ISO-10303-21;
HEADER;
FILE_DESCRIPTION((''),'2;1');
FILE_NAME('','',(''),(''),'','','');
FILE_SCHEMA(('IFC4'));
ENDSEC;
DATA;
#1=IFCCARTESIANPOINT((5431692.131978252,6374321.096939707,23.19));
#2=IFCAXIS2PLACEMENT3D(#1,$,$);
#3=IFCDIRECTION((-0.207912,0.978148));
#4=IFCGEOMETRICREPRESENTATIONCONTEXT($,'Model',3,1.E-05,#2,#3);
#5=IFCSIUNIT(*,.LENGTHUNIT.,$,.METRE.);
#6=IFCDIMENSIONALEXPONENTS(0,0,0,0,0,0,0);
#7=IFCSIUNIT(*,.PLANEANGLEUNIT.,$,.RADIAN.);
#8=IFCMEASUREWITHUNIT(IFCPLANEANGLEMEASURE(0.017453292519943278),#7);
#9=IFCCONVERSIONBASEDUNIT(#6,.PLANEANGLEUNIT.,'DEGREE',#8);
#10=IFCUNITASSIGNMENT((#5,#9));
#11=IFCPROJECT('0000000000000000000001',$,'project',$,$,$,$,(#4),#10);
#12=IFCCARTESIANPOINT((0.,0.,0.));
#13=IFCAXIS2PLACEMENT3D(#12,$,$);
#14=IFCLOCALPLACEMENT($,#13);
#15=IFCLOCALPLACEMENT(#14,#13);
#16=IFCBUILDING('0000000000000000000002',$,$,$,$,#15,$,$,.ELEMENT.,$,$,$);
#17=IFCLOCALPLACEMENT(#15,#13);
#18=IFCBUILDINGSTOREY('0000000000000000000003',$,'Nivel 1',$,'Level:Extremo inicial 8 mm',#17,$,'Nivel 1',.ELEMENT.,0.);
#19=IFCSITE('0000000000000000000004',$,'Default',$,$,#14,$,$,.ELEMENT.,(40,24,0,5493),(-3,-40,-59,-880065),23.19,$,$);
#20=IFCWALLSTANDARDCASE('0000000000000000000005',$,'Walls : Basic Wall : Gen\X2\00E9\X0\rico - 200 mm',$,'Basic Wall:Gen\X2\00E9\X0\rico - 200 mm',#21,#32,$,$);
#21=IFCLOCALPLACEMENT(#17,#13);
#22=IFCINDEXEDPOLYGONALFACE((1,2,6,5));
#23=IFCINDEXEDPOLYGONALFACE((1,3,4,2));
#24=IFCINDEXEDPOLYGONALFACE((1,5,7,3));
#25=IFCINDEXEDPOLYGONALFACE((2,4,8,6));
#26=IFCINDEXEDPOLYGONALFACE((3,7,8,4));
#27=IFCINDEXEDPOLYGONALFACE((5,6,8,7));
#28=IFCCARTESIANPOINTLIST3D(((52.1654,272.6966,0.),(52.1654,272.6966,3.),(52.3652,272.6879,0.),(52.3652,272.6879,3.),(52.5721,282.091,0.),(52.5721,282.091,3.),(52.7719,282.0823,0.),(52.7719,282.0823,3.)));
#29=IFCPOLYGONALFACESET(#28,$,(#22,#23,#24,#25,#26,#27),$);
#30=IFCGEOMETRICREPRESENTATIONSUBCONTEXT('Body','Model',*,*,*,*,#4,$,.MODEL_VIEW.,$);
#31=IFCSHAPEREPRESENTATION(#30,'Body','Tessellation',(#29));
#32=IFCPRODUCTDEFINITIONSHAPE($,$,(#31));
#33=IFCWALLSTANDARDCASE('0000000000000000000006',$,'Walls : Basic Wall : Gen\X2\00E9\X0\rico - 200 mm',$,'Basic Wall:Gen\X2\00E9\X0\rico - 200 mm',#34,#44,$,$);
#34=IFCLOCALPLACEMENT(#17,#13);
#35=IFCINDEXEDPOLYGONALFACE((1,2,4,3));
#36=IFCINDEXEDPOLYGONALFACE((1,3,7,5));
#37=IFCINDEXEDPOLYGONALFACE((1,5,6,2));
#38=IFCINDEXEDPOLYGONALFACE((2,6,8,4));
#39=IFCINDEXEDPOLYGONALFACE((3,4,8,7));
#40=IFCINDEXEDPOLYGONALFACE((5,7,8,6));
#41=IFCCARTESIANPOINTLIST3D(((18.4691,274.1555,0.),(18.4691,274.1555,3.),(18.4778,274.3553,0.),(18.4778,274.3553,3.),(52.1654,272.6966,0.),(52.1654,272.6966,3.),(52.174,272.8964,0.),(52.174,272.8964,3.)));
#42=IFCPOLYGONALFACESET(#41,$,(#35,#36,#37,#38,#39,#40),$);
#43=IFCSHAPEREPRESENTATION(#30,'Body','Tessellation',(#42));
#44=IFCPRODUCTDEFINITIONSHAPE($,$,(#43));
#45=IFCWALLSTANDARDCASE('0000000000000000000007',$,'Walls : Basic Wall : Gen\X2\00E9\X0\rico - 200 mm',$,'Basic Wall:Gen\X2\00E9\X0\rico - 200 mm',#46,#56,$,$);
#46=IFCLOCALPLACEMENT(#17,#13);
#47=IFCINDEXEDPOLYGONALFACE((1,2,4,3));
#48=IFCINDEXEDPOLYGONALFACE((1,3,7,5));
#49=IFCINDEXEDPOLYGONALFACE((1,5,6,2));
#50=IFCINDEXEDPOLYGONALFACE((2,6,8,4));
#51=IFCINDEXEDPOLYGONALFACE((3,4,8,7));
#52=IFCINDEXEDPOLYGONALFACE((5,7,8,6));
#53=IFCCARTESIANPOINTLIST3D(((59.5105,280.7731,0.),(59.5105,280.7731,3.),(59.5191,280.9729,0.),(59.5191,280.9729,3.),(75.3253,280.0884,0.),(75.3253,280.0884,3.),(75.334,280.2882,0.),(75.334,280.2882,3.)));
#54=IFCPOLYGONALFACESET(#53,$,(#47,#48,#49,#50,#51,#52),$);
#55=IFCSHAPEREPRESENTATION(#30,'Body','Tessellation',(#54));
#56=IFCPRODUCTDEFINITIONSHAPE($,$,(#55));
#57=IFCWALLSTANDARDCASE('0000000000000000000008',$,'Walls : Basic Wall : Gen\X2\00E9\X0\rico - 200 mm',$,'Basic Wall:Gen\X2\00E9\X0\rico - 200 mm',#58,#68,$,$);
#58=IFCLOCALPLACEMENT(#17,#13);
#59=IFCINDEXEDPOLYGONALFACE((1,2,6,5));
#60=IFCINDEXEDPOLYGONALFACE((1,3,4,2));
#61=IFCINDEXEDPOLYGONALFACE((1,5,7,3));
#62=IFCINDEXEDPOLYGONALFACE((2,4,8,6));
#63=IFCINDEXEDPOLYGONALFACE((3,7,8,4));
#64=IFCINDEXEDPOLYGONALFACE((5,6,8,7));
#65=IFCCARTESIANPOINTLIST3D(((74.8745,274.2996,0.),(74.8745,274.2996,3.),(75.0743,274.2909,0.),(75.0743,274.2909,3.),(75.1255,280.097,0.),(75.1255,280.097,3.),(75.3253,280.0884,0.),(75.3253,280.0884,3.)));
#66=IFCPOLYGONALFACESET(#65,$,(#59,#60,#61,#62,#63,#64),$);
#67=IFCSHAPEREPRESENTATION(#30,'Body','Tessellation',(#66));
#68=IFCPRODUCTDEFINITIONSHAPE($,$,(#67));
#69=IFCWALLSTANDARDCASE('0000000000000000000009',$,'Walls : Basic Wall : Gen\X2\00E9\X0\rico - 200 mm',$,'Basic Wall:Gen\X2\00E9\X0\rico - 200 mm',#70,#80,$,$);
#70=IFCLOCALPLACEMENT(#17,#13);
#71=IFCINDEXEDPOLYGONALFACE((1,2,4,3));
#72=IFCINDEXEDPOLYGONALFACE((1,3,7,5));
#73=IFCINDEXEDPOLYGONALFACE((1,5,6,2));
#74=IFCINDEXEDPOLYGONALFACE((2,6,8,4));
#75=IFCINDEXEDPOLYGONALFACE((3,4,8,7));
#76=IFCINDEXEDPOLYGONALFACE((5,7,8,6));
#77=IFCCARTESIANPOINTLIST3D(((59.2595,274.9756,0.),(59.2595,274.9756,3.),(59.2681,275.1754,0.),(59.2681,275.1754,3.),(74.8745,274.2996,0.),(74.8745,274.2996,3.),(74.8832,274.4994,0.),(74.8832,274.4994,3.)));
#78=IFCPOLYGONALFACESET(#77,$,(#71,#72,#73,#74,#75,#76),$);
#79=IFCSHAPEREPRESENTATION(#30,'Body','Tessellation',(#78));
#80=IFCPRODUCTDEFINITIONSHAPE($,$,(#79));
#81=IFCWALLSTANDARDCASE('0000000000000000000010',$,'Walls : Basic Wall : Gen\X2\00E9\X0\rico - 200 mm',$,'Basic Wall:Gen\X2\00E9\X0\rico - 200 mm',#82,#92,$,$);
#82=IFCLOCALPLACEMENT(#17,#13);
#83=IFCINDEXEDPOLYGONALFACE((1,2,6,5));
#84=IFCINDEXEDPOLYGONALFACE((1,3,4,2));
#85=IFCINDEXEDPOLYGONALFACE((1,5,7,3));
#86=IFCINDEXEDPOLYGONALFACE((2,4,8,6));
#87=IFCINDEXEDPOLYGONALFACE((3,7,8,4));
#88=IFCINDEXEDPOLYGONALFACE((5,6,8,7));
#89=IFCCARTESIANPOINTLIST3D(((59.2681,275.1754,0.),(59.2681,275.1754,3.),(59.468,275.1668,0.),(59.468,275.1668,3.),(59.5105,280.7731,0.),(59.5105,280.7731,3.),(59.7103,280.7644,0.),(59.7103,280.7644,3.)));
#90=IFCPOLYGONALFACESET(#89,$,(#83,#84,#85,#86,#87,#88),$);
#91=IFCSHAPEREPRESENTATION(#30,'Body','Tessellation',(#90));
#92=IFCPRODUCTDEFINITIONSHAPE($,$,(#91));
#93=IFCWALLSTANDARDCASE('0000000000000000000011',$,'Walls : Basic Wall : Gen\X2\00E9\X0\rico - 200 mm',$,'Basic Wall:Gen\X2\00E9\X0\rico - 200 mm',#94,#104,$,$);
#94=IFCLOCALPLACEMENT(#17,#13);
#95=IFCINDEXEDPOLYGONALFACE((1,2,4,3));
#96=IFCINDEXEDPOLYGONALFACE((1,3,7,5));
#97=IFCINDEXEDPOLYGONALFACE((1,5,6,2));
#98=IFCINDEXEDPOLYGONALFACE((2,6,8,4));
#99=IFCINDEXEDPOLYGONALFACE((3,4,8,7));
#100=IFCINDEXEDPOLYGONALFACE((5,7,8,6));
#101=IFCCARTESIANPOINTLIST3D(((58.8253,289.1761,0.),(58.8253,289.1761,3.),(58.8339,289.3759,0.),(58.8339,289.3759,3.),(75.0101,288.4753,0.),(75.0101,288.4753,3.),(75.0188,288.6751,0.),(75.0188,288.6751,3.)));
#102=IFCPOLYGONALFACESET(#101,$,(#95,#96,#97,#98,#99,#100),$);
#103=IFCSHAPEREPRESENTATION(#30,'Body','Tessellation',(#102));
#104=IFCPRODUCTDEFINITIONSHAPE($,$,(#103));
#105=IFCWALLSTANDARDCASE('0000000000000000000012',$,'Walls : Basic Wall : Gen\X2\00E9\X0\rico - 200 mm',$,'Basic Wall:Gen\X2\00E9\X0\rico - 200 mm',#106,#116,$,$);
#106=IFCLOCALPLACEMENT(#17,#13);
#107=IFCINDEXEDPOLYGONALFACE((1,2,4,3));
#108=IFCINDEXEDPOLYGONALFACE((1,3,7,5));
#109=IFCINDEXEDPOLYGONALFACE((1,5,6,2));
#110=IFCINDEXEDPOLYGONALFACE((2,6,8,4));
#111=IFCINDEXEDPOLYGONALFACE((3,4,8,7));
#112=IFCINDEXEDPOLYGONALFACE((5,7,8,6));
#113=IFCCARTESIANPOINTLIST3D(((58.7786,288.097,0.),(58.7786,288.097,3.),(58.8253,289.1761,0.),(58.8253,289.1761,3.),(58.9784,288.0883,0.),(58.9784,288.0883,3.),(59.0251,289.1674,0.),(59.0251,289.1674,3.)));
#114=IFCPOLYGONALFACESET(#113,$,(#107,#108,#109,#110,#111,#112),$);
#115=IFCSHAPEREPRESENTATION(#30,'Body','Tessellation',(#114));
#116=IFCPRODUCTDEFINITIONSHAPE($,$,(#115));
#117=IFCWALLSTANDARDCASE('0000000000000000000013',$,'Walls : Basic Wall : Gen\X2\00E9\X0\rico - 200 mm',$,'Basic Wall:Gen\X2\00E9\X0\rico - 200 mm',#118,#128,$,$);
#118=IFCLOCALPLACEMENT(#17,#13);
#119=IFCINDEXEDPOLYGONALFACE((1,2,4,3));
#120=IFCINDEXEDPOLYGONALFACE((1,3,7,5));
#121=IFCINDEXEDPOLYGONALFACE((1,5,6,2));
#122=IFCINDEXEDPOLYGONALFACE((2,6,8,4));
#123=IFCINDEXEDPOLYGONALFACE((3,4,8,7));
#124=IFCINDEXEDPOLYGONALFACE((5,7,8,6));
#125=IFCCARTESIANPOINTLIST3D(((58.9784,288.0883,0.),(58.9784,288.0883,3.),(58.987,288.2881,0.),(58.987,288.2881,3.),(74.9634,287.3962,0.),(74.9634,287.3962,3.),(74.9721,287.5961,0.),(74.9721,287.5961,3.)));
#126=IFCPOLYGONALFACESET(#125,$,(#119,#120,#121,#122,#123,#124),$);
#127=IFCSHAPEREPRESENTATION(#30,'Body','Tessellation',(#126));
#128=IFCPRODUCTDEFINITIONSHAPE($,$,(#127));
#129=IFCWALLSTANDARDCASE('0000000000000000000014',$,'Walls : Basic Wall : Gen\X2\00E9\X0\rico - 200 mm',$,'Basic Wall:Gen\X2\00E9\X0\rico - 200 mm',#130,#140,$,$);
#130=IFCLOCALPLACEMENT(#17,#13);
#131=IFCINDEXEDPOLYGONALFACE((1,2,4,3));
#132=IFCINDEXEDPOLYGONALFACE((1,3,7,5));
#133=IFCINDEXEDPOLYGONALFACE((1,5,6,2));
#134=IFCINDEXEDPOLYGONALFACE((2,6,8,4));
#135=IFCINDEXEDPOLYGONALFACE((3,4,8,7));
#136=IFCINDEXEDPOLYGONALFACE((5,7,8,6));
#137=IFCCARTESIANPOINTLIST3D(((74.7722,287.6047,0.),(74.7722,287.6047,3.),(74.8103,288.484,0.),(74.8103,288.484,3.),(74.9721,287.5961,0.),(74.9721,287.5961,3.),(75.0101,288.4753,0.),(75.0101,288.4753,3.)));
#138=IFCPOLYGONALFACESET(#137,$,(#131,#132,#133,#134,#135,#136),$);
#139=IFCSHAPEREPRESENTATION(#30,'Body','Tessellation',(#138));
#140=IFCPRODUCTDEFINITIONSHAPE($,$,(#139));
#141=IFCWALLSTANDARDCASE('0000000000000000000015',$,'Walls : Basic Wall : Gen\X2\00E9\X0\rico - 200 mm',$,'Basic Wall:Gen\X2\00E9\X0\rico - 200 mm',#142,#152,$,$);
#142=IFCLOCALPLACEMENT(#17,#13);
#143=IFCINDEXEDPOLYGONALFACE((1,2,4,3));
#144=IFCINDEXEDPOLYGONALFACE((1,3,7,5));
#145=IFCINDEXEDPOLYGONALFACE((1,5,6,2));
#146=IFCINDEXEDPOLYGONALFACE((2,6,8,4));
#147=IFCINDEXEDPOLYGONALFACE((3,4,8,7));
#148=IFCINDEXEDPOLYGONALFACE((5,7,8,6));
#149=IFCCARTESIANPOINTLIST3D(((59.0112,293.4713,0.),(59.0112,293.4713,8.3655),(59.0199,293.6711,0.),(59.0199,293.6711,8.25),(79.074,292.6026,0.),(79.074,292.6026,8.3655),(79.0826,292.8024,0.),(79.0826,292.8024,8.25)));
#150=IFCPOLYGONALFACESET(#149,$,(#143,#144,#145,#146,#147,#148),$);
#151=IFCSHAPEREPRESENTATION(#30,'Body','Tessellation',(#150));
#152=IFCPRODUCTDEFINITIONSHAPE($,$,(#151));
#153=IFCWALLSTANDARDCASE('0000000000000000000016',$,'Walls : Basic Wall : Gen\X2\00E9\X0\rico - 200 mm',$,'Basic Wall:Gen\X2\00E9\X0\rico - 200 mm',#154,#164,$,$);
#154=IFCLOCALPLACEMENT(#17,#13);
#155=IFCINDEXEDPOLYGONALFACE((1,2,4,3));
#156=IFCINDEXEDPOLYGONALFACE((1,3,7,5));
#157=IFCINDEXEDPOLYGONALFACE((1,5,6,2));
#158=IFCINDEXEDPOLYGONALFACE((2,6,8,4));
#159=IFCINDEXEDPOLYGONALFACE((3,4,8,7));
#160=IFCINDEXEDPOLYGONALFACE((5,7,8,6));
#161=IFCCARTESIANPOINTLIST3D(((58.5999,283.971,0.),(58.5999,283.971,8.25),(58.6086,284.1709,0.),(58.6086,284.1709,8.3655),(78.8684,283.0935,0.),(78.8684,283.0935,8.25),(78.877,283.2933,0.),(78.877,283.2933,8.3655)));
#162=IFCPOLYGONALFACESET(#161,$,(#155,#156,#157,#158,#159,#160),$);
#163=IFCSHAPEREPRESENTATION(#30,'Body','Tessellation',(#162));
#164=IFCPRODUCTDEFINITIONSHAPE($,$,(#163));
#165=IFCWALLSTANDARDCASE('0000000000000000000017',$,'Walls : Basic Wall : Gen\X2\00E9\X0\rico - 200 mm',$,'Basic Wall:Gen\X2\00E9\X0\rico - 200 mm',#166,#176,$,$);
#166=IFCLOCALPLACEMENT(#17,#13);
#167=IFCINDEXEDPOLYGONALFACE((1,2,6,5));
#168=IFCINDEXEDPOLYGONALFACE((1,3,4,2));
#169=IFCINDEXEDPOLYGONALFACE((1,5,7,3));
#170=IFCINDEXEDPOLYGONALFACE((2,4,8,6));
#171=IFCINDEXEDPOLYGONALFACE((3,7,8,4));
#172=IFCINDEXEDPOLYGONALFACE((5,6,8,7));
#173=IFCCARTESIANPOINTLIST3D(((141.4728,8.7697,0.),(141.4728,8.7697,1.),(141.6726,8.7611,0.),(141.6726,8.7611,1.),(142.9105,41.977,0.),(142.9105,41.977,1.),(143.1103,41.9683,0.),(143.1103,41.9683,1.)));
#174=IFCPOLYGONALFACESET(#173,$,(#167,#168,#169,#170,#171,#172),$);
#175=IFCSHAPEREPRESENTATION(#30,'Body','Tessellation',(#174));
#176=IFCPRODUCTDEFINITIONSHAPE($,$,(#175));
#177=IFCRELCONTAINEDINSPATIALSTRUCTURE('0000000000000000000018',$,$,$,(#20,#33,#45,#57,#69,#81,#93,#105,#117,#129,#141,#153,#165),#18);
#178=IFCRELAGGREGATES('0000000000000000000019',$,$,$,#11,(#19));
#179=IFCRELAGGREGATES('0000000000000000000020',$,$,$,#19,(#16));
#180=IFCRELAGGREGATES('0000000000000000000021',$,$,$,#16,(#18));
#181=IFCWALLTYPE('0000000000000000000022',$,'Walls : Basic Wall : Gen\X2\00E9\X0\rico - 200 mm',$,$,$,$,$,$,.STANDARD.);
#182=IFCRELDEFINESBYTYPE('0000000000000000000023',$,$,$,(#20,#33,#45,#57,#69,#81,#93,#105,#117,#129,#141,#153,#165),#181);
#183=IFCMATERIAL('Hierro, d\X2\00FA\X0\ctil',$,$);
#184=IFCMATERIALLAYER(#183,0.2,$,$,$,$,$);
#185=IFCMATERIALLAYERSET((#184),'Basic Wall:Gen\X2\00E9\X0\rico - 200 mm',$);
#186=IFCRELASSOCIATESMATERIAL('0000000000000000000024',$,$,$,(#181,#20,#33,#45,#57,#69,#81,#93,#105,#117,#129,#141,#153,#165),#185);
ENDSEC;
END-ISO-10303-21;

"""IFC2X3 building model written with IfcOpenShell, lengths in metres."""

from ifc_helpers import new_model, entity, si_unit, converted_unit, direction, frame, frame_2d, origin, place, context, subcontext, project, spatial, polyline, rectangle, extrude, clip, bounded_halfspace, material, layer, layer_set, layer_usage, type_object, element, save


model = new_model("IFC2X3")

# Units and contexts
model_context = context("Model", 3, precision=1e-05, world=frame((5431692.131978252, 6374321.096939707, 23.19)), true_north=direction((-0.207912, 0.978148)))
body_context = subcontext(model_context, "Body", "Model", "MODEL_VIEW")
ifc_project = project(units=[si_unit("LENGTHUNIT", "METRE"), converted_unit("PLANEANGLEUNIT", "DEGREE", entity("IfcPlaneAngleMeasure", 0.017453292519943278), si_unit("PLANEANGLEUNIT", "RADIAN"), dimensions=[0, 0, 0, 0, 0, 0, 0])], contexts=[model_context])

# Site, building, storey
site_placement = place(None, origin())
site = spatial("IfcSite", under=ifc_project, at=site_placement, Name="Default", CompositionType="ELEMENT", RefLatitude=(40, 24, 0, 5493), RefLongitude=(-3, -40, -59, -880065), RefElevation=23.19)
building_placement = place(site_placement, origin())
building = spatial("IfcBuilding", under=site, at=building_placement, CompositionType="ELEMENT")
storey_placement = place(building_placement, origin())
storey = spatial("IfcBuildingStorey", under=building, at=storey_placement, Name="Nivel 1", ObjectType="Level:Extremo inicial 8 mm", LongName="Nivel 1", CompositionType="ELEMENT", Elevation=0.0)

# Walls
ifc_material_1 = material(Name="Hierro, dúctil")
ifc_layer = layer(ifc_material_1, 0.2)
ifc_layer_set = layer_set([ifc_layer], Name="Basic Wall:Genérico - 200 mm")
ifc_layer_usage_1 = layer_usage(ifc_layer_set, "AXIS2", "NEGATIVE", 0.1)
wall_type = type_object("IfcWallType", Name="Walls : Basic Wall : Genérico - 200 mm", PredefinedType="STANDARD", material=ifc_layer_set)
wall_1_placement = place(storey_placement, frame((52.672, 282.0867, 0.0), z_axis=(0.0, 0.0, 1.0), x_axis=(-0.043255, -0.999064, 0.0)))
element("IfcWallStandardCase", 1, at=wall_1_placement, inside=storey, type_object=wall_type, material=ifc_layer_usage_1, Name="Walls : Basic Wall : Genérico - 200 mm", ObjectType="Basic Wall:Genérico - 200 mm", context=body_context, shape_type="SweptSolid", body=[
    extrude(rectangle(XDim=9.4032, YDim=0.2, at=frame_2d((4.7016, 0.0), x_axis=(-1.0, 0.0))), origin(), (0.0, 0.0, 1.0), 3.0),
])
ifc_layer_usage_2 = layer_usage(ifc_layer_set, "AXIS2", "NEGATIVE", 0.1)
wall_2_placement = place(storey_placement, frame((52.1697, 272.7965, 0.0), z_axis=(0.0, 0.0, 1.0), x_axis=(-0.999064, 0.043255, 0.0)))
element("IfcWallStandardCase", 2, at=wall_2_placement, inside=storey, type_object=wall_type, material=ifc_layer_usage_2, Name="Walls : Basic Wall : Genérico - 200 mm", ObjectType="Basic Wall:Genérico - 200 mm", context=body_context, shape_type="SweptSolid", body=[
    extrude(rectangle(XDim=33.7278, YDim=0.2, at=frame_2d((16.8639, 0.0), x_axis=(-1.0, 0.0))), origin(), (0.0, 0.0, 1.0), 3.0),
])
ifc_layer_usage_3 = layer_usage(ifc_layer_set, "AXIS2", "NEGATIVE", 0.1)
wall_3_placement = place(storey_placement, frame((59.5148, 280.873, 0.0), z_axis=(0.0, 0.0, 1.0), x_axis=(0.999064, -0.043255, 0.0)))
element("IfcWallStandardCase", 3, at=wall_3_placement, inside=storey, type_object=wall_type, material=ifc_layer_usage_3, Name="Walls : Basic Wall : Genérico - 200 mm", ObjectType="Basic Wall:Genérico - 200 mm", context=body_context, shape_type="SweptSolid", body=[
    extrude(rectangle(XDim=15.8297, YDim=0.2, at=frame_2d((7.9148, 0.0), x_axis=(-1.0, 0.0))), origin(), (0.0, 0.0, 1.0), 3.0),
])
ifc_layer_usage_4 = layer_usage(ifc_layer_set, "AXIS2", "NEGATIVE", 0.1)
wall_4_placement = place(storey_placement, frame((75.2254, 280.0927, 0.0), z_axis=(0.0, 0.0, 1.0), x_axis=(-0.043255, -0.999064, 0.0)))
element("IfcWallStandardCase", 4, at=wall_4_placement, inside=storey, type_object=wall_type, material=ifc_layer_usage_4, Name="Walls : Basic Wall : Genérico - 200 mm", ObjectType="Basic Wall:Genérico - 200 mm", context=body_context, shape_type="SweptSolid", body=[
    extrude(rectangle(XDim=5.8029, YDim=0.2, at=frame_2d((2.9014, 0.0), x_axis=(-1.0, 0.0))), origin(), (0.0, 0.0, 1.0), 3.0),
])
ifc_layer_usage_5 = layer_usage(ifc_layer_set, "AXIS2", "NEGATIVE", 0.1)
wall_5_placement = place(storey_placement, frame((74.8789, 274.3995, 0.0), z_axis=(0.0, 0.0, 1.0), x_axis=(-0.999064, 0.043255, 0.0)))
element("IfcWallStandardCase", 5, at=wall_5_placement, inside=storey, type_object=wall_type, material=ifc_layer_usage_5, Name="Walls : Basic Wall : Genérico - 200 mm", ObjectType="Basic Wall:Genérico - 200 mm", context=body_context, shape_type="SweptSolid", body=[
    extrude(rectangle(XDim=15.6297, YDim=0.2, at=frame_2d((7.8148, 0.0), x_axis=(-1.0, 0.0))), origin(), (0.0, 0.0, 1.0), 3.0),
])
ifc_layer_usage_6 = layer_usage(ifc_layer_set, "AXIS2", "NEGATIVE", 0.1)
wall_6_placement = place(storey_placement, frame((59.368, 275.1711, 0.0), z_axis=(0.0, 0.0, 1.0), x_axis=(0.043255, 0.999064, 0.0)))
element("IfcWallStandardCase", 6, at=wall_6_placement, inside=storey, type_object=wall_type, material=ifc_layer_usage_6, Name="Walls : Basic Wall : Genérico - 200 mm", ObjectType="Basic Wall:Genérico - 200 mm", context=body_context, shape_type="SweptSolid", body=[
    extrude(rectangle(XDim=5.6029, YDim=0.2, at=frame_2d((2.8014, 0.0), x_axis=(-1.0, 0.0))), origin(), (0.0, 0.0, 1.0), 3.0),
])
ifc_layer_usage_7 = layer_usage(ifc_layer_set, "AXIS2", "NEGATIVE", 0.1)
wall_7_placement = place(storey_placement, frame((75.0144, 288.5752, 0.0), z_axis=(0.0, 0.0, 1.0), x_axis=(-0.999064, 0.043255, 0.0)))
element("IfcWallStandardCase", 7, at=wall_7_placement, inside=storey, type_object=wall_type, material=ifc_layer_usage_7, Name="Walls : Basic Wall : Genérico - 200 mm", ObjectType="Basic Wall:Genérico - 200 mm", context=body_context, shape_type="SweptSolid", body=[
    extrude(rectangle(XDim=16.2, YDim=0.2, at=frame_2d((8.1, 0.0), x_axis=(-1.0, 0.0))), origin(), (0.0, 0.0, 1.0), 3.0),
])
ifc_layer_usage_8 = layer_usage(ifc_layer_set, "AXIS2", "NEGATIVE", 0.1)
wall_8_placement = place(storey_placement, frame((58.9252, 289.1717, 0.0), z_axis=(0.0, 0.0, 1.0), x_axis=(-0.043255, -0.999064, 0.0)))
element("IfcWallStandardCase", 8, at=wall_8_placement, inside=storey, type_object=wall_type, material=ifc_layer_usage_8, Name="Walls : Basic Wall : Genérico - 200 mm", ObjectType="Basic Wall:Genérico - 200 mm", context=body_context, shape_type="SweptSolid", body=[
    extrude(rectangle(XDim=1.0801, YDim=0.2, at=frame_2d((0.54, 0.0), x_axis=(-1.0, 0.0))), origin(), (0.0, 0.0, 1.0), 3.0),
])
ifc_layer_usage_9 = layer_usage(ifc_layer_set, "AXIS2", "NEGATIVE", 0.1)
wall_9_placement = place(storey_placement, frame((58.9827, 288.1882, 0.0), z_axis=(0.0, 0.0, 1.0), x_axis=(0.999064, -0.043255, 0.0)))
element("IfcWallStandardCase", 9, at=wall_9_placement, inside=storey, type_object=wall_type, material=ifc_layer_usage_9, Name="Walls : Basic Wall : Genérico - 200 mm", ObjectType="Basic Wall:Genérico - 200 mm", context=body_context, shape_type="SweptSolid", body=[
    extrude(rectangle(XDim=16.0, YDim=0.2, at=frame_2d((8.0, 0.0), x_axis=(-1.0, 0.0))), origin(), (0.0, 0.0, 1.0), 3.0),
])
ifc_layer_usage_10 = layer_usage(ifc_layer_set, "AXIS2", "NEGATIVE", 0.1)
wall_10_placement = place(storey_placement, frame((74.8721, 287.6004, 0.0), z_axis=(0.0, 0.0, 1.0), x_axis=(0.043255, 0.999064, 0.0)))
element("IfcWallStandardCase", 10, at=wall_10_placement, inside=storey, type_object=wall_type, material=ifc_layer_usage_10, Name="Walls : Basic Wall : Genérico - 200 mm", ObjectType="Basic Wall:Genérico - 200 mm", context=body_context, shape_type="SweptSolid", body=[
    extrude(rectangle(XDim=0.8801, YDim=0.2, at=frame_2d((0.44, 0.0), x_axis=(-1.0, 0.0))), origin(), (0.0, 0.0, 1.0), 3.0),
])
ifc_layer_usage_11 = layer_usage(ifc_layer_set, "AXIS2", "NEGATIVE", 0.1)
wall_11_placement = place(storey_placement, frame((79.0783, 292.7025, 0.0), z_axis=(0.0, 0.0, 1.0), x_axis=(-0.999064, 0.043255, 0.0)))
element("IfcWallStandardCase", 11, at=wall_11_placement, inside=storey, type_object=wall_type, material=ifc_layer_usage_11, Name="Walls : Basic Wall : Genérico - 200 mm", ObjectType="Basic Wall:Genérico - 200 mm", context=body_context, shape_type="Clipping", body=[
    clip(extrude(rectangle(XDim=20.0815, YDim=0.2, at=frame_2d((10.0408, 0.0), x_axis=(-1.0, 0.0))), origin(), (0.0, 0.0, 1.0), 8.3655), bounded_halfspace(frame((0.0, -0.1, 8.25), z_axis=(0.0, -0.5, 0.866025), x_axis=(1.0, 0.0, 0.0)), False, frame((0.0, -0.1, 8.25)), polyline([(0.0, 0.0), (20.0815, 0.0), (20.0815, 0.2), (19.8815, 0.2), (0.0, 0.2), (0.0, 0.0)]))),
])
ifc_layer_usage_12 = layer_usage(ifc_layer_set, "AXIS2", "NEGATIVE", 0.1)
wall_12_placement = place(storey_placement, frame((78.8727, 283.1934, 0.0), z_axis=(0.0, 0.0, 1.0), x_axis=(-0.999064, 0.043255, 0.0)))
element("IfcWallStandardCase", 12, at=wall_12_placement, inside=storey, type_object=wall_type, material=ifc_layer_usage_12, Name="Walls : Basic Wall : Genérico - 200 mm", ObjectType="Basic Wall:Genérico - 200 mm", context=body_context, shape_type="Clipping", body=[
    clip(extrude(rectangle(XDim=20.2874, YDim=0.2, at=frame_2d((10.1437, 0.0), x_axis=(-1.0, 0.0))), origin(), (0.0, 0.0, 1.0), 8.3655), bounded_halfspace(frame((0.0, -0.1, 8.3655), z_axis=(0.0, 0.5, 0.866025), x_axis=(-1.0, 0.0, 0.0)), False, frame((0.0, -0.1, 8.3655)), polyline([(0.0, 0.0), (0.2, 0.0), (20.0874, 0.0), (20.2874, 0.0), (20.2874, 0.2), (0.0, 0.2), (0.0, 0.0)]))),
])
ifc_layer_usage_13 = layer_usage(ifc_layer_set, "AXIS2", "NEGATIVE", 0.1)
wall_13_placement = place(storey_placement, frame((141.5727, 8.7654, 0.0), z_axis=(0.0, 0.0, 1.0), x_axis=(0.043255, 0.999064, 0.0)))
element("IfcWallStandardCase", 13, at=wall_13_placement, inside=storey, type_object=wall_type, material=ifc_layer_usage_13, Name="Walls : Basic Wall : Genérico - 200 mm", ObjectType="Basic Wall:Genérico - 200 mm", context=body_context, shape_type="SweptSolid", body=[
    extrude(rectangle(XDim=33.2383, YDim=0.2, at=frame_2d((16.6192, 0.0), x_axis=(-1.0, 0.0))), origin(), (0.0, 0.0, 1.0), 1.0),
])

save(model, "model.ifc")
